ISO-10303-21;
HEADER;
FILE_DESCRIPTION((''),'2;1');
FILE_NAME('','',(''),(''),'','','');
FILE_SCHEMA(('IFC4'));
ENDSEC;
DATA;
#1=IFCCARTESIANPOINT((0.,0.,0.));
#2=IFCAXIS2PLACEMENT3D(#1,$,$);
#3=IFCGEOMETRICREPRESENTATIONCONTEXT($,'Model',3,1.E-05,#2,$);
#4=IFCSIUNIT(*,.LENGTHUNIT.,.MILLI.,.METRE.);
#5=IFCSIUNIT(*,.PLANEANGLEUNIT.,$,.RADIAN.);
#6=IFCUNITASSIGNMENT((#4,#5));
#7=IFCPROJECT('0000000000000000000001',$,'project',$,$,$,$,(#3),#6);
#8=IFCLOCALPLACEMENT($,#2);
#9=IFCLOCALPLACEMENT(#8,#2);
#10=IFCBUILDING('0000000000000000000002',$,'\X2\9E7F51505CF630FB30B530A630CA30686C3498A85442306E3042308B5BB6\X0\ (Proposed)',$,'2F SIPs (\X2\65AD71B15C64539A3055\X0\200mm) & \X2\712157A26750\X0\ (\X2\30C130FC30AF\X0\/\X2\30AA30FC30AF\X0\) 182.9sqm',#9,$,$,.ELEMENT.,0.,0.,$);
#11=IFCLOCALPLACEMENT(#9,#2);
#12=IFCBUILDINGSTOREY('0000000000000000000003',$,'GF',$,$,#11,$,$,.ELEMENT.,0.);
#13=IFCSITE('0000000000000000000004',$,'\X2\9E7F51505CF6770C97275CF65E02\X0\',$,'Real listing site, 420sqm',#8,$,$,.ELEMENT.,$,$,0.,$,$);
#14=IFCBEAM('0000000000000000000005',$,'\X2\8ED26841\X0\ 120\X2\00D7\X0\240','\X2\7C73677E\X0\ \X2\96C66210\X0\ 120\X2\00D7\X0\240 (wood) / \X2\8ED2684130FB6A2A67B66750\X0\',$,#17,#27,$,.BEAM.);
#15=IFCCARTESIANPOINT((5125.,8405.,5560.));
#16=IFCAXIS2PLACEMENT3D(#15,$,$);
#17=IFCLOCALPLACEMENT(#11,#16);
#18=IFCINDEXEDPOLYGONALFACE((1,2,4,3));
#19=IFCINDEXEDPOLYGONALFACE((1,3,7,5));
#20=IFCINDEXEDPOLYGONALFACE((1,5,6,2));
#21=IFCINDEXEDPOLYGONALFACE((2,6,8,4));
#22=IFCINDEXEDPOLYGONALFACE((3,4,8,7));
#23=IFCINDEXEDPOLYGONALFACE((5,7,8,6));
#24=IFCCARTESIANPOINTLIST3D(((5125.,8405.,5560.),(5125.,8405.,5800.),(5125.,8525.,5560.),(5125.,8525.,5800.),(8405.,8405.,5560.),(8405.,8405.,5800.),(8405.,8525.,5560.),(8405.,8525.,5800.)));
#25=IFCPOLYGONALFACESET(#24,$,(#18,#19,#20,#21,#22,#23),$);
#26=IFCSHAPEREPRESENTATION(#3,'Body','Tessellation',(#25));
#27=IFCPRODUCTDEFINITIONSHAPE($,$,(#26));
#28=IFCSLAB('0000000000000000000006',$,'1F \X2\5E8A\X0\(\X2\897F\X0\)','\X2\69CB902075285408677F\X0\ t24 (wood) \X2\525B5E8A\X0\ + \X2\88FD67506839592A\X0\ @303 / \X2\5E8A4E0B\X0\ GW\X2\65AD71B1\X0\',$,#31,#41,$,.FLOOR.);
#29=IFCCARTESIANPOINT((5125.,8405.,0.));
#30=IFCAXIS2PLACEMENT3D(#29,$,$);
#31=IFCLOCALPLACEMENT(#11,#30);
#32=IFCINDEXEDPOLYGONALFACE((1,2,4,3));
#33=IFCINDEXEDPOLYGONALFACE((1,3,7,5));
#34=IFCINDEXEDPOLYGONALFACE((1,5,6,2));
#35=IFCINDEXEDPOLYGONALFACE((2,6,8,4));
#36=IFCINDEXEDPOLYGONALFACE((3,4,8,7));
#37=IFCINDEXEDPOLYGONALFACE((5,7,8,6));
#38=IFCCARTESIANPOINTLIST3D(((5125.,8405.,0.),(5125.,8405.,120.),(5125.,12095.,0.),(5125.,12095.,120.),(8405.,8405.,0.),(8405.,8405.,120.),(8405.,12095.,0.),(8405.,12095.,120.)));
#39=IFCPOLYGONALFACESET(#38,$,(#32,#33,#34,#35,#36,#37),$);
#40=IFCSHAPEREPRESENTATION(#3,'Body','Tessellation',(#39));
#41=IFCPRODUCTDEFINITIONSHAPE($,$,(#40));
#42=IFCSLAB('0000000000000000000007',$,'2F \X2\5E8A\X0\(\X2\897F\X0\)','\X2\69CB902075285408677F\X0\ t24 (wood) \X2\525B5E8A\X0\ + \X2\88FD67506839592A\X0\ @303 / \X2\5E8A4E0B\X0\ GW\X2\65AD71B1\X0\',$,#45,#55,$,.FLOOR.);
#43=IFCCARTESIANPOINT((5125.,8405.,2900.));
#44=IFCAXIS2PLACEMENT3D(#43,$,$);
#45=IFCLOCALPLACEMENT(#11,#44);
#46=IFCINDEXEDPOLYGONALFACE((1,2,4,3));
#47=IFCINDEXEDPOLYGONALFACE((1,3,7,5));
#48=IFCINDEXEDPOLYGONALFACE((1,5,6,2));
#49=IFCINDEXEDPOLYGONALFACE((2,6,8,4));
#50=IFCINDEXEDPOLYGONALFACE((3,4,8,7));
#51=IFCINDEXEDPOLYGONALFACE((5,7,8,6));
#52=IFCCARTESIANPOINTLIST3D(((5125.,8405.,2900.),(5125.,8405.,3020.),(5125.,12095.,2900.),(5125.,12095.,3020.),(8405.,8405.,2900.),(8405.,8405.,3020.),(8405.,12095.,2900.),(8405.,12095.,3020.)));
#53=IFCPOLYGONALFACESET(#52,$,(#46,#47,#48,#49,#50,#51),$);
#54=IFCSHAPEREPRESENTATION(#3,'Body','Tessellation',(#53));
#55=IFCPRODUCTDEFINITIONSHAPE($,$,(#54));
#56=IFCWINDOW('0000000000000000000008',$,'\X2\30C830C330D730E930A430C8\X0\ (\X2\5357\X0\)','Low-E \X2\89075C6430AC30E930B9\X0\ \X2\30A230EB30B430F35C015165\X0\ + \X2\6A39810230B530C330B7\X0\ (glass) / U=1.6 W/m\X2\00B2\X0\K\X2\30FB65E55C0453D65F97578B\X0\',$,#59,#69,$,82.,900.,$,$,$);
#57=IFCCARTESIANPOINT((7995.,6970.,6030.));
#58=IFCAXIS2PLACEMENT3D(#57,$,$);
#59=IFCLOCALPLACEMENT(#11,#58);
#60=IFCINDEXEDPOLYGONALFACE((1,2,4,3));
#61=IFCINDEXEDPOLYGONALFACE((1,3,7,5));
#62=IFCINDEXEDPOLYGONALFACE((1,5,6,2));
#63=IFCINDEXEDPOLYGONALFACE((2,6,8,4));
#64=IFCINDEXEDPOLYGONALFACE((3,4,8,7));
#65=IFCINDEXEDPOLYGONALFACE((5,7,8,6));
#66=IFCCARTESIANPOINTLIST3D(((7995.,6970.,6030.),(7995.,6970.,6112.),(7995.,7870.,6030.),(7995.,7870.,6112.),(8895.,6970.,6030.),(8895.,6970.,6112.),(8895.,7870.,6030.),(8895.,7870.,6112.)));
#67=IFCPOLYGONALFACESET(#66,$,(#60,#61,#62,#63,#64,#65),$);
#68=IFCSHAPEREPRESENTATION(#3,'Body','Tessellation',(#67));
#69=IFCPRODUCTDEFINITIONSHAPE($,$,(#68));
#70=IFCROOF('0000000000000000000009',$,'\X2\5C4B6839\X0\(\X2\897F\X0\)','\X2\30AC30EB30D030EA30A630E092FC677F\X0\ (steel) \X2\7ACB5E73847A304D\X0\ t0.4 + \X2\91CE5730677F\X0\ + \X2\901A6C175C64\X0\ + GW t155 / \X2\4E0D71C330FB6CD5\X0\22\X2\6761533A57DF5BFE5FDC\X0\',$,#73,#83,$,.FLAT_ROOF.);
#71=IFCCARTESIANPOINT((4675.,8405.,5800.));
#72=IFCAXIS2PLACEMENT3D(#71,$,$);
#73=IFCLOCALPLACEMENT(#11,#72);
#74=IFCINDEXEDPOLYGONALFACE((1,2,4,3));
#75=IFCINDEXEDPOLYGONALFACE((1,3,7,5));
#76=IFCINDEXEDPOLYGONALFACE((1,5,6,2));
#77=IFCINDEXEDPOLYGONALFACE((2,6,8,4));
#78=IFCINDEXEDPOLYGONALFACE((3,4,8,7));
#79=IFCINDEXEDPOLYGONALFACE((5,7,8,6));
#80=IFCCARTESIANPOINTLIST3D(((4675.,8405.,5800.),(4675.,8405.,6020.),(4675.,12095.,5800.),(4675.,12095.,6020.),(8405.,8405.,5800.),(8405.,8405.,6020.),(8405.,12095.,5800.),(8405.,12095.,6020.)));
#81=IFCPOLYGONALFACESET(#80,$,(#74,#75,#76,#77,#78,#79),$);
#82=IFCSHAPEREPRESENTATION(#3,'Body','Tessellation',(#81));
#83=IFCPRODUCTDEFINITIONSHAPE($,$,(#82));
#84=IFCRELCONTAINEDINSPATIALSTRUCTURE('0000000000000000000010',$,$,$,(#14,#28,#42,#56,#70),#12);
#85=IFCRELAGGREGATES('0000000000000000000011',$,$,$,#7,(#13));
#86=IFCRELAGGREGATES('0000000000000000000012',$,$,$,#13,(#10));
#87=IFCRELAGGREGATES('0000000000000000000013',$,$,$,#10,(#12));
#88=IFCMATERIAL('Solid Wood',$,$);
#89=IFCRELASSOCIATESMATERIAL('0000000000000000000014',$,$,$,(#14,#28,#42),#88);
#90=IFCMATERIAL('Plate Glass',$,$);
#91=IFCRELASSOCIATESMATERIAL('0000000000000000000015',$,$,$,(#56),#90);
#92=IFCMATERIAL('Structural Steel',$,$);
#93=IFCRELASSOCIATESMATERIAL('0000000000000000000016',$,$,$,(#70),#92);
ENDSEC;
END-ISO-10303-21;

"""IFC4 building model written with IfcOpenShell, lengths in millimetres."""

from ifc_helpers import new_model, si_unit, frame, frame_2d, origin, place, context, project, spatial, rectangle, extrude, material, element, save


model = new_model("IFC4")

# Units and contexts
model_context = context("Model", 3, precision=1e-05, world=origin())
ifc_project = project(units=[si_unit("LENGTHUNIT", "METRE", prefix="MILLI"), si_unit("PLANEANGLEUNIT", "RADIAN")], contexts=[model_context])

# Site, building, storey
site_placement = place(None, origin())
site = spatial("IfcSite", under=ifc_project, at=site_placement, Name="鹿児島県霧島市", ObjectType="Real listing site, 420sqm", CompositionType="ELEMENT", RefElevation=0.0)
building_placement = place(site_placement, origin())
building = spatial("IfcBuilding", under=site, at=building_placement, Name="鹿児島・サウナと水風呂のある家 (Proposed)", ObjectType="2F SIPs (断熱層厚さ200mm) & 無垢材 (チーク/オーク) 182.9sqm", CompositionType="ELEMENT", ElevationOfRefHeight=0.0, ElevationOfTerrain=0.0)
storey_placement = place(building_placement, origin())
storey = spatial("IfcBuildingStorey", under=building, at=storey_placement, Name="GF", CompositionType="ELEMENT", Elevation=0.0)

# Shared definitions
ifc_material_1 = material(Name="Solid Wood")

# Beam
beam_1_placement = place(storey_placement, frame((5125.0, 8405.0, 5560.0)))
element("IfcBeam", 1, at=beam_1_placement, inside=storey, material=ifc_material_1, Name="軒桁 120×240", Description="米松 集成 120×240 (wood) / 軒桁・横架材", PredefinedType="BEAM", context=model_context, shape_type="SweptSolid", body=[
    extrude(rectangle(XDim=3280.0, YDim=120.0, at=frame_2d((1640.0, 60.0))), frame((5125.0, 8405.0, 5560.0)), (0.0, 0.0, 1.0), 240.0),
])

# Slabs
slab_1_placement = place(storey_placement, frame((5125.0, 8405.0, 0.0)))
element("IfcSlab", 2, at=slab_1_placement, inside=storey, material=ifc_material_1, Name="1F 床(西)", Description="構造用合板 t24 (wood) 剛床 + 製材根太 @303 / 床下 GW断熱", PredefinedType="FLOOR", context=model_context, shape_type="SweptSolid", body=[
    extrude(rectangle(XDim=3280.0, YDim=3690.0, at=frame_2d((1640.0, 1845.0))), frame((5125.0, 8405.0, 0.0)), (0.0, 0.0, 1.0), 120.0),
])
slab_2_placement = place(storey_placement, frame((5125.0, 8405.0, 2900.0)))
element("IfcSlab", 3, at=slab_2_placement, inside=storey, material=ifc_material_1, Name="2F 床(西)", Description="構造用合板 t24 (wood) 剛床 + 製材根太 @303 / 床下 GW断熱", PredefinedType="FLOOR", context=model_context, shape_type="SweptSolid", body=[
    extrude(rectangle(XDim=3280.0, YDim=3690.0, at=frame_2d((1640.0, 1845.0))), frame((5125.0, 8405.0, 2900.0)), (0.0, 0.0, 1.0), 120.0),
])

# Window
ifc_material_2 = material(Name="Plate Glass")
window_placement = place(storey_placement, frame((7995.0, 6970.0, 6030.0)))
element("IfcWindow", 4, at=window_placement, inside=storey, material=ifc_material_2, Name="トップライト (南)", Description="Low-E 複層ガラス アルゴン封入 + 樹脂サッシ (glass) / U=1.6 W/m²K・日射取得型", OverallHeight=82.0, OverallWidth=900.0, context=model_context, shape_type="SweptSolid", body=[
    extrude(rectangle(XDim=900.0, YDim=900.0, at=frame_2d((450.0, 450.0))), frame((7995.0, 6970.0, 6030.0)), (0.0, 0.0, 1.0), 82.0),
])

# Roof
ifc_material_3 = material(Name="Structural Steel")
for number, where, name in (
    (5, (4675.0, 8405.0, 5800.0), "屋根(西)"),
):
    element("IfcRoof", number, at=place(storey_placement, frame(where)), inside=storey, material=ifc_material_3, Name=name, Description="ガルバリウム鋼板 (steel) 立平葺き t0.4 + 野地板 + 通気層 + GW t155 / 不燃・法22条区域対応", PredefinedType="FLAT_ROOF", context=model_context, shape_type="SweptSolid", body=[
        extrude(rectangle(XDim=3730.0, YDim=3690.0, at=frame_2d((1865.0, 1845.0))), frame((4675.0, 8405.0, 5800.0)), (0.0, 0.0, 1.0), 220.0),
    ])

save(model, "model.ifc")
